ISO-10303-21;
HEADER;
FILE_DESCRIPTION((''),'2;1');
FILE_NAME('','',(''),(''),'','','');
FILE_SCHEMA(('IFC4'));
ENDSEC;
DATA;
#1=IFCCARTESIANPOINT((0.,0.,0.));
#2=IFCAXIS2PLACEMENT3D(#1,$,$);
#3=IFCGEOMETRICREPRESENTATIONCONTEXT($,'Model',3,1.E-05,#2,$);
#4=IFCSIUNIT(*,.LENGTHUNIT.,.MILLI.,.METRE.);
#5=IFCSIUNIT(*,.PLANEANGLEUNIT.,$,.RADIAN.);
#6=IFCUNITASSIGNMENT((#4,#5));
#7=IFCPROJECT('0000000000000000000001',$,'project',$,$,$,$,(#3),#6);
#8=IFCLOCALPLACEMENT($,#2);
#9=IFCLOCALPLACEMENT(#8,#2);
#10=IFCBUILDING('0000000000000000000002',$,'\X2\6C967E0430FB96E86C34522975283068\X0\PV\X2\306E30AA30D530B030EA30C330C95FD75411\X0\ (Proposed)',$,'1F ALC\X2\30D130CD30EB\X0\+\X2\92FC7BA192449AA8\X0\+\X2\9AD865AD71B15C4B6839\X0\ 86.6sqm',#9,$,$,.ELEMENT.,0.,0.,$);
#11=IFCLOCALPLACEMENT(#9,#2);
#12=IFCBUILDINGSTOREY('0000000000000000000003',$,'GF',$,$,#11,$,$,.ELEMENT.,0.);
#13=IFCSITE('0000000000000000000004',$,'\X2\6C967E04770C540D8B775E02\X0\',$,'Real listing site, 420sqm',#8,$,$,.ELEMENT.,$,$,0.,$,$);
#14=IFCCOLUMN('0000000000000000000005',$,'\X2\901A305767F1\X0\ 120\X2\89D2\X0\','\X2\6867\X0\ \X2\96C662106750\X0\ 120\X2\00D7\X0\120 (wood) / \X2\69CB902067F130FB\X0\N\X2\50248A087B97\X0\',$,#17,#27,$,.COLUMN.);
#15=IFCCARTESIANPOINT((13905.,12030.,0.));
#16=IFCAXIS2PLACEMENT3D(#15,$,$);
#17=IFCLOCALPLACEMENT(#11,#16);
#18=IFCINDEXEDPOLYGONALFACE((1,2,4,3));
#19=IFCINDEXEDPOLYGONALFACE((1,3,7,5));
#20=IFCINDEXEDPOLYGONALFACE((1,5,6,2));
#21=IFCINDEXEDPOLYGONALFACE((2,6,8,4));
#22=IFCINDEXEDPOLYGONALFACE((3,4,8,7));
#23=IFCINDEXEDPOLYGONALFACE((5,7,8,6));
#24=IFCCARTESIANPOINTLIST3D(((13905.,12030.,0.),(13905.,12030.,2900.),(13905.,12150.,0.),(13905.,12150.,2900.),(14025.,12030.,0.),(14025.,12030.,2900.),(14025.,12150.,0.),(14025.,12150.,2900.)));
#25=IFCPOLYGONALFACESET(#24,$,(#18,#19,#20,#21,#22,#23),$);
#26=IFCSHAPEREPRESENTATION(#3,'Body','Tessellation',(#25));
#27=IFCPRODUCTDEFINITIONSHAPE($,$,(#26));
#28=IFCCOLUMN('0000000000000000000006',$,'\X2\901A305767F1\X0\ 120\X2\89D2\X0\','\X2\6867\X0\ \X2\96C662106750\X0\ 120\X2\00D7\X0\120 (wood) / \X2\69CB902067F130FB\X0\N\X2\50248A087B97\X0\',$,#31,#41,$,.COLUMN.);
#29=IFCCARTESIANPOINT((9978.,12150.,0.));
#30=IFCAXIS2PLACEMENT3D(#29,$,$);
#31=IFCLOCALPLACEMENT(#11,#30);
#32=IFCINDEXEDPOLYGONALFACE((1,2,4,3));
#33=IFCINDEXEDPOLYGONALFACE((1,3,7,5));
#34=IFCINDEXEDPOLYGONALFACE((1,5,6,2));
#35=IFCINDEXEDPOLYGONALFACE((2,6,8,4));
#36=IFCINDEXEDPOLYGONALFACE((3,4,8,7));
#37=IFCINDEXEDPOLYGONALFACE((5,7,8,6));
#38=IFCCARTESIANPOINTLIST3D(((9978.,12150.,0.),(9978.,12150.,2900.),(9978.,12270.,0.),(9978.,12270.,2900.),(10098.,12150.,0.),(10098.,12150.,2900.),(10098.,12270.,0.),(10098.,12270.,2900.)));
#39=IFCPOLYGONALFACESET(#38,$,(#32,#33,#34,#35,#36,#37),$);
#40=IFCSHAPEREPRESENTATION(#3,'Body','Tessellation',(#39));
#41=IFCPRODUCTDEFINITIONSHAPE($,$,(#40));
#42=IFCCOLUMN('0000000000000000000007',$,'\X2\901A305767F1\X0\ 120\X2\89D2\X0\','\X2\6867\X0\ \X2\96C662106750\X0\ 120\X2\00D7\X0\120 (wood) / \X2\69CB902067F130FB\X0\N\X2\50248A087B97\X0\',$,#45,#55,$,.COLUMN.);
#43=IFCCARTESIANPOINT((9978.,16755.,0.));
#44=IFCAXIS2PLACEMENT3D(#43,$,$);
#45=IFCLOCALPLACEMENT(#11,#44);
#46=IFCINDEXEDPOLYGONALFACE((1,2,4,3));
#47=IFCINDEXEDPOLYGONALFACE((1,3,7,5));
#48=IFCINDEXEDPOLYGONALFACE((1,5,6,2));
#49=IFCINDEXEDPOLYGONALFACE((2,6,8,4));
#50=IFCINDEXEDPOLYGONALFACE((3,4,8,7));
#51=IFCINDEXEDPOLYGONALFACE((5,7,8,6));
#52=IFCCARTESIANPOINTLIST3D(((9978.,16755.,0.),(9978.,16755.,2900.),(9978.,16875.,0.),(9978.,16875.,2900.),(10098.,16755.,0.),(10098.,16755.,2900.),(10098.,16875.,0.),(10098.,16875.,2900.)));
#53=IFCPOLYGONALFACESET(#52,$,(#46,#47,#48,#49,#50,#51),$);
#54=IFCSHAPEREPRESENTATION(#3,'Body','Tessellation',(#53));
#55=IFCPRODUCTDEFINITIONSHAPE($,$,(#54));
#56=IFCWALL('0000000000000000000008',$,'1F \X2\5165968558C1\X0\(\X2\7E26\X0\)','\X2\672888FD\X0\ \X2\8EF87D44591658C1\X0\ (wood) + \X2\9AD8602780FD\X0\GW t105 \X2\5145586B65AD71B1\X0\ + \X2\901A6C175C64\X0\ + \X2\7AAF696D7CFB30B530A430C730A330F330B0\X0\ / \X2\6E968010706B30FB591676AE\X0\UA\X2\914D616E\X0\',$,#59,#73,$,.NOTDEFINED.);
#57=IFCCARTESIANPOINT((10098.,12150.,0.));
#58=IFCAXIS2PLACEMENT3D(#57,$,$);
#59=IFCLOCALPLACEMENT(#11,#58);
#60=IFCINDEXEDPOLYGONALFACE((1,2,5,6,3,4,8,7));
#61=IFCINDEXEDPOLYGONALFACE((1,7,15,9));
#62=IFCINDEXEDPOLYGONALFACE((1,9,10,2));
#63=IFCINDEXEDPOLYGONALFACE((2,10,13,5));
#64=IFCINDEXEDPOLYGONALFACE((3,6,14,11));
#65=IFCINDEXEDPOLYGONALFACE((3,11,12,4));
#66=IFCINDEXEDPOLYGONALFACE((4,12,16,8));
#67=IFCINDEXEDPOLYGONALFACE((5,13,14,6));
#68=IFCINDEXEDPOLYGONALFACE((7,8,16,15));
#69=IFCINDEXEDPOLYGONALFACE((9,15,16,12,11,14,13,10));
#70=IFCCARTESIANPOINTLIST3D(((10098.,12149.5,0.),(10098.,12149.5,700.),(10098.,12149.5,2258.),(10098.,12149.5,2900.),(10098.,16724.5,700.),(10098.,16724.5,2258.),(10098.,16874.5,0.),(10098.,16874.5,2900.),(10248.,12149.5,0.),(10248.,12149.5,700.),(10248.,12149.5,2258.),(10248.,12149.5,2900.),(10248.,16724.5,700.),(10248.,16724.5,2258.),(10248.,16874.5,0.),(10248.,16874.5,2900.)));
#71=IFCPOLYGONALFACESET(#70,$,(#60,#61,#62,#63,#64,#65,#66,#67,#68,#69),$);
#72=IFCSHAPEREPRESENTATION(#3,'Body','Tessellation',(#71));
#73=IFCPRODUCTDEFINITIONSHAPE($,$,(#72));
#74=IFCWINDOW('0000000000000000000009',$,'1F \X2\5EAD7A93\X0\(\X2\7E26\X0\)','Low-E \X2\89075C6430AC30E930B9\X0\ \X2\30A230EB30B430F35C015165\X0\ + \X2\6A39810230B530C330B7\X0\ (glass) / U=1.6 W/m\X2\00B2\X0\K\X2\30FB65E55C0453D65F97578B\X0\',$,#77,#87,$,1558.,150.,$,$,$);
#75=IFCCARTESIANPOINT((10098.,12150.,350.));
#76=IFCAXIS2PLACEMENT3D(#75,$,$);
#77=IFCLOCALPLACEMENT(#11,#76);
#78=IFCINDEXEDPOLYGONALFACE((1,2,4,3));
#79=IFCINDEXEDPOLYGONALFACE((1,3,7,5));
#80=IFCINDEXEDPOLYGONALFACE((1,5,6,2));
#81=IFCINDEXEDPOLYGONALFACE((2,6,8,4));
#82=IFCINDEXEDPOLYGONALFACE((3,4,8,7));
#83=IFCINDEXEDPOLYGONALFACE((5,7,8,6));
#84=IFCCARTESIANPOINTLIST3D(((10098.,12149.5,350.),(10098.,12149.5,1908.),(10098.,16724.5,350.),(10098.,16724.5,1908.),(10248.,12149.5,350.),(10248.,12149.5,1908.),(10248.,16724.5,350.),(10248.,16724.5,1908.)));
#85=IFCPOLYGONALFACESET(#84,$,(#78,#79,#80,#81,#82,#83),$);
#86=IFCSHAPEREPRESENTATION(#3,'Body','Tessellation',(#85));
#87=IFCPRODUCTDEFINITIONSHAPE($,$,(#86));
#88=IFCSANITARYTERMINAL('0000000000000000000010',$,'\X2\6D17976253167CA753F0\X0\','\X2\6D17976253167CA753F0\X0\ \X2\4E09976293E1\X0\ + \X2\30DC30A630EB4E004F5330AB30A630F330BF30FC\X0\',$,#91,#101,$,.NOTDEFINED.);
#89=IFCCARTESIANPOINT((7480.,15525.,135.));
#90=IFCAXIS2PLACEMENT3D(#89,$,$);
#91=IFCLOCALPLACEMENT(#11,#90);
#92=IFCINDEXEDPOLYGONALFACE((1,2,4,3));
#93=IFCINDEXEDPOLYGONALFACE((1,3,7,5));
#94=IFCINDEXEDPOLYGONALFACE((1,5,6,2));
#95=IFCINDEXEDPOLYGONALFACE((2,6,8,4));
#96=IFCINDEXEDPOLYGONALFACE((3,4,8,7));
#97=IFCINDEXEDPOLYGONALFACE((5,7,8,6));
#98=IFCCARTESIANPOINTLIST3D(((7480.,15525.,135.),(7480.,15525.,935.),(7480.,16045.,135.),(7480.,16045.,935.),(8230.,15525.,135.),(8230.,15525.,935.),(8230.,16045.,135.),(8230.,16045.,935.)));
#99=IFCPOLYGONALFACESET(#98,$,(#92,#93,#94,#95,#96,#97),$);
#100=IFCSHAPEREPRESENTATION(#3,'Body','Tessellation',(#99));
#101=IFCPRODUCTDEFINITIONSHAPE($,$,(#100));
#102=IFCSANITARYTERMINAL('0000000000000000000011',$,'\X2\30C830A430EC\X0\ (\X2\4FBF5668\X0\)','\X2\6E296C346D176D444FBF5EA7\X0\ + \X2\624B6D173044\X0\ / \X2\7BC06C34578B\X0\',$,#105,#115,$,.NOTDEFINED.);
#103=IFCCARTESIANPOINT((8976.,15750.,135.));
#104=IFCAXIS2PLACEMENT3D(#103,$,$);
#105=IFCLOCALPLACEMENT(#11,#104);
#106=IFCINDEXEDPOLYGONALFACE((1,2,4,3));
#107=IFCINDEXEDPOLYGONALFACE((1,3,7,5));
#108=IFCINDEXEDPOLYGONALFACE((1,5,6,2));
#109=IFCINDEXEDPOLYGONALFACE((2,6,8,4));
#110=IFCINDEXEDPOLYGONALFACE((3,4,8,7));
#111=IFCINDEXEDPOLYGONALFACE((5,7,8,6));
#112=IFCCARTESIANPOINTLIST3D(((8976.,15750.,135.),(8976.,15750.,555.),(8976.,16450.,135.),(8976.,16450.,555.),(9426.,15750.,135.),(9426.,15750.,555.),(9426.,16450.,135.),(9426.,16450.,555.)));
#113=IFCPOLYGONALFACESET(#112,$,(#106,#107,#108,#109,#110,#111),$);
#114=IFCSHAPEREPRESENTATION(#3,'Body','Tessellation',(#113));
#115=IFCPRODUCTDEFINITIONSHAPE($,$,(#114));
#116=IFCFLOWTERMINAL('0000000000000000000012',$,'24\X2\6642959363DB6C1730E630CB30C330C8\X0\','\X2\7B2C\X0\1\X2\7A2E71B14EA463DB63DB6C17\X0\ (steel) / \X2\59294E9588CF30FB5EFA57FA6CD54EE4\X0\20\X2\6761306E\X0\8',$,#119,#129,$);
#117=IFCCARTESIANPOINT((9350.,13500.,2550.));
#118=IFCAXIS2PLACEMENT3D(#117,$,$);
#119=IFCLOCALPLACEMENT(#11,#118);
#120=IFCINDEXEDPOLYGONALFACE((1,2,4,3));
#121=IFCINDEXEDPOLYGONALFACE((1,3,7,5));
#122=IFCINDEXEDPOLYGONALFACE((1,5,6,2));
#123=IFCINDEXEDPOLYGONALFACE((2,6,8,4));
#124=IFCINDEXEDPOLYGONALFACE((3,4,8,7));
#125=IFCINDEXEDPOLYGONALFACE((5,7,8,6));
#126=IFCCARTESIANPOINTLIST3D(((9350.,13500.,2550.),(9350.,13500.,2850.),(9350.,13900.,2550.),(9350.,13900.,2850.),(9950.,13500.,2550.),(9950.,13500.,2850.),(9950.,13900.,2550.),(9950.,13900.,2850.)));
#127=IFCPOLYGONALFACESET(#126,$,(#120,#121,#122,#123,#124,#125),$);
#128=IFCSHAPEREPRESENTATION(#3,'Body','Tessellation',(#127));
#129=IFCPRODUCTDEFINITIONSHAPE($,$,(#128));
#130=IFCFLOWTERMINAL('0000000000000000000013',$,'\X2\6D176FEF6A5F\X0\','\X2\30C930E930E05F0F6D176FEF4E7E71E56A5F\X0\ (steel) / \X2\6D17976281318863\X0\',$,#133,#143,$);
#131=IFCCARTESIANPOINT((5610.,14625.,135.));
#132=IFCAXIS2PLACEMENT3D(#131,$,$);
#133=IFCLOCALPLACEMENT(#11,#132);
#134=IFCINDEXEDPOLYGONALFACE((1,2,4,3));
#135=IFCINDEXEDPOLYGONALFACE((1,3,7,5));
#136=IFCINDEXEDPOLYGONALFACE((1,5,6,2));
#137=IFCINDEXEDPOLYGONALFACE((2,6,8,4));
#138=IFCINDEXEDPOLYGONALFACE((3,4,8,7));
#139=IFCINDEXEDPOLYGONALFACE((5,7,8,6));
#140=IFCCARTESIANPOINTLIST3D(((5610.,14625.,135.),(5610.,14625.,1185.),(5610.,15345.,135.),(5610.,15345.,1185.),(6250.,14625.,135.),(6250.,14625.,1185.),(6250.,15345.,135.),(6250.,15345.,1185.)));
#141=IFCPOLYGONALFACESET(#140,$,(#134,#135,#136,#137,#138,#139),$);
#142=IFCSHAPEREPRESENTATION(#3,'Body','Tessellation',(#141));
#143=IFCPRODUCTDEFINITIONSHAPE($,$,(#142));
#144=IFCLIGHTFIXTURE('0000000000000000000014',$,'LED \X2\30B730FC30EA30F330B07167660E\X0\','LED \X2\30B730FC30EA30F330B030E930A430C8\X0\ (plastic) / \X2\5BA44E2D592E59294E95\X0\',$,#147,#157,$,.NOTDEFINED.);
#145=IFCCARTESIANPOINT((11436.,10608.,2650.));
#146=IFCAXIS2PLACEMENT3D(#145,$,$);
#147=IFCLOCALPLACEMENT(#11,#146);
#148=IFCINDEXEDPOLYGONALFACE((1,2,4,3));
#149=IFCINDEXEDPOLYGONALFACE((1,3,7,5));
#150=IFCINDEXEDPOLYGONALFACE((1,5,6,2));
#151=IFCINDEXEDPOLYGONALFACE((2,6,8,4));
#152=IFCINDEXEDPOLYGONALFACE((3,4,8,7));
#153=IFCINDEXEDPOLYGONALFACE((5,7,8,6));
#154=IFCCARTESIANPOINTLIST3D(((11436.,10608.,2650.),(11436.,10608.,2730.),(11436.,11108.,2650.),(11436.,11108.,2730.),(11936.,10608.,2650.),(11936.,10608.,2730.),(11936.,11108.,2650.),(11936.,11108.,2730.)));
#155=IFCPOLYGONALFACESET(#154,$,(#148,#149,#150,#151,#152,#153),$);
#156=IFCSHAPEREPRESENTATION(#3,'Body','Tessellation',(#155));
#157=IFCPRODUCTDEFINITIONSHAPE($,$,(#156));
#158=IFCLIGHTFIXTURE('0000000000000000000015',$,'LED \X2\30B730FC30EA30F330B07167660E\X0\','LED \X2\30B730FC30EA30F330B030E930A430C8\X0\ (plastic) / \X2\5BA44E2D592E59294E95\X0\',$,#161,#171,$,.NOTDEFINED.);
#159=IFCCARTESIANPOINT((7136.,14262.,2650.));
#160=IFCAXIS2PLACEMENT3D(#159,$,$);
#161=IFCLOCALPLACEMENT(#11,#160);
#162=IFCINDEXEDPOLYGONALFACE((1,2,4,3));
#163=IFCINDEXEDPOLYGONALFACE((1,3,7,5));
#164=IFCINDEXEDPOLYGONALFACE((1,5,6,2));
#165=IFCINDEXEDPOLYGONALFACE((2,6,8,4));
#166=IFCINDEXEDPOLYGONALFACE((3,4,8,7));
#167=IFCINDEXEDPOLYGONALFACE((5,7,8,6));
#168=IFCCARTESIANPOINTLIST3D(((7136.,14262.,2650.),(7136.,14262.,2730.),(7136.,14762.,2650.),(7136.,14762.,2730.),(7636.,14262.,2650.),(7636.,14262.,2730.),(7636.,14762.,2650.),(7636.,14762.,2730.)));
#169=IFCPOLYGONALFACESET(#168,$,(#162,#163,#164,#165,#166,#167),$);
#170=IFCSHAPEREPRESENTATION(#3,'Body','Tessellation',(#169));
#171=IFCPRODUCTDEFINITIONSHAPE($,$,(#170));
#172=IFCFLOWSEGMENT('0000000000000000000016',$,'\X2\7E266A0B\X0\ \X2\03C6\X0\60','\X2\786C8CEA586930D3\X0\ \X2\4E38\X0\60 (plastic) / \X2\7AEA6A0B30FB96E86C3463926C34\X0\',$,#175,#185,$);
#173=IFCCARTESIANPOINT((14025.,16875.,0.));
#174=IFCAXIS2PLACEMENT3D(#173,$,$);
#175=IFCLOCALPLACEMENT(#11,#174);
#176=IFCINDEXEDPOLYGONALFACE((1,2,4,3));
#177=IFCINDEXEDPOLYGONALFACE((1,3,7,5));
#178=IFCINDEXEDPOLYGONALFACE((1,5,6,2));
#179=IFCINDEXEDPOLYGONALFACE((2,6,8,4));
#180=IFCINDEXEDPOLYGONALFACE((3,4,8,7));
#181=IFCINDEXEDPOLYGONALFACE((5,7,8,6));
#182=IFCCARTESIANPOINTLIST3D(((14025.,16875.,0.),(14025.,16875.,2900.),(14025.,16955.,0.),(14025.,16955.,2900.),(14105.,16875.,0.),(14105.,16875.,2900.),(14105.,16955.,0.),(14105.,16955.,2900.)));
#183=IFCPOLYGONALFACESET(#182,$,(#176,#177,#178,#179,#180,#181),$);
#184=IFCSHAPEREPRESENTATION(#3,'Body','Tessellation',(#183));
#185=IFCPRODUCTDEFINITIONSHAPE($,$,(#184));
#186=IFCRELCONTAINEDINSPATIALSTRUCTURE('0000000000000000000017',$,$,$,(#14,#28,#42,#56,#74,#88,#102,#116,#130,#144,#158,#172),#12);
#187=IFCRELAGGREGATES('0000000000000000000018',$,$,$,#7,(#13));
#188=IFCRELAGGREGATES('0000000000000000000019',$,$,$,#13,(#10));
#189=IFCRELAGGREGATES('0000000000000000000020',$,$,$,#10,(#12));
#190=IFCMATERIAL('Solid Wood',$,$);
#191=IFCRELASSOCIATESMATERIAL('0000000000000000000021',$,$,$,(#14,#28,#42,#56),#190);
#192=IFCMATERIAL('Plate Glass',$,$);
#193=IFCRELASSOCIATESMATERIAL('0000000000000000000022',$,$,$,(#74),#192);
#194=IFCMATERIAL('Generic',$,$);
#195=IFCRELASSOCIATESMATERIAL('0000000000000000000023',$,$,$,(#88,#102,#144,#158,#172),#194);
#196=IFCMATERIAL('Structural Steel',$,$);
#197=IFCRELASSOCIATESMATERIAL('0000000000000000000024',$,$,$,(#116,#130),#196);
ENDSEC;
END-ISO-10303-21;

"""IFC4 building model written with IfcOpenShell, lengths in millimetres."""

from ifc_helpers import new_model, si_unit, frame, frame_2d, origin, place, context, project, spatial, rectangle, extrude, material, element, fill, save


model = new_model("IFC4")

# Units and contexts
model_context = context("Model", 3, precision=1e-05, world=origin())
ifc_project = project(units=[si_unit("LENGTHUNIT", "METRE", prefix="MILLI"), si_unit("PLANEANGLEUNIT", "RADIAN")], contexts=[model_context])

# Site, building, storey
site_placement = place(None, origin())
site = spatial("IfcSite", under=ifc_project, at=site_placement, Name="沖縄県名護市", ObjectType="Real listing site, 420sqm", CompositionType="ELEMENT", RefElevation=0.0)
building_placement = place(site_placement, origin())
building = spatial("IfcBuilding", under=site, at=building_placement, Name="沖縄・雨水利用とPVのオフグリッド志向 (Proposed)", ObjectType="1F ALCパネル+鋼管鉄骨+高断熱屋根 86.6sqm", CompositionType="ELEMENT", ElevationOfRefHeight=0.0, ElevationOfTerrain=0.0)
storey_placement = place(building_placement, origin())
storey = spatial("IfcBuildingStorey", under=building, at=storey_placement, Name="GF", CompositionType="ELEMENT", Elevation=0.0)

# Columns
ifc_material_1 = material(Name="Solid Wood")
column_1_placement = place(storey_placement, frame((13905.0, 12030.0, 0.0)))
element("IfcColumn", 1, at=column_1_placement, inside=storey, material=ifc_material_1, Name="通し柱 120角", Description="桧 集成材 120×120 (wood) / 構造柱・N値計算", PredefinedType="COLUMN", context=model_context, shape_type="SweptSolid", body=[
    extrude(rectangle(XDim=120.0, YDim=120.0, at=frame_2d((60.0, 60.0))), frame((13905.0, 12030.0, 0.0)), (0.0, 0.0, 1.0), 2900.0),
])
column_2_placement = place(storey_placement, frame((9978.0, 12150.0, 0.0)))
element("IfcColumn", 2, at=column_2_placement, inside=storey, material=ifc_material_1, Name="通し柱 120角", Description="桧 集成材 120×120 (wood) / 構造柱・N値計算", PredefinedType="COLUMN", context=model_context, shape_type="SweptSolid", body=[
    extrude(rectangle(XDim=120.0, YDim=120.0, at=frame_2d((60.0, 60.0))), frame((9978.0, 12150.0, 0.0)), (0.0, 0.0, 1.0), 2900.0),
])
column_3_placement = place(storey_placement, frame((9978.0, 16755.0, 0.0)))
element("IfcColumn", 3, at=column_3_placement, inside=storey, material=ifc_material_1, Name="通し柱 120角", Description="桧 集成材 120×120 (wood) / 構造柱・N値計算", PredefinedType="COLUMN", context=model_context, shape_type="SweptSolid", body=[
    extrude(rectangle(XDim=120.0, YDim=120.0, at=frame_2d((60.0, 60.0))), frame((9978.0, 16755.0, 0.0)), (0.0, 0.0, 1.0), 2900.0),
])

# Wall, opening, window
wall_1_placement = place(storey_placement, frame((10098.0, 12150.0, 0.0)))
wall_1 = element("IfcWall", 4, at=wall_1_placement, inside=storey, material=ifc_material_1, Name="1F 入隅壁(縦)", Description="木製 軸組外壁 (wood) + 高性能GW t105 充填断熱 + 通気層 + 窯業系サイディング / 準耐火・外皮UA配慮", PredefinedType="NOTDEFINED", context=model_context, shape_type="SweptSolid", body=[
    extrude(rectangle(XDim=150.0, YDim=4725.0, at=frame_2d((75.0, 2362.0))), frame((10098.0, 12150.0, 0.0)), (0.0, 0.0, 1.0), 2900.0),
])
opening_placement = place(storey_placement, frame((10098.0, 12150.0, 350.0)))
opening = element("IfcOpeningElement", 5, at=opening_placement, cuts=wall_1, PredefinedType="NOTDEFINED", context=model_context, shape_type="SweptSolid", body=[
    extrude(rectangle(XDim=150.0, YDim=4575.0, at=frame_2d((75.0, 2287.0))), frame((10098.0, 12150.0, 350.0)), (0.0, 0.0, 1.0), 1558.0),
])
ifc_material_2 = material(Name="Plate Glass")
window_placement = place(storey_placement, frame((10098.0, 12150.0, 350.0)))
window = element("IfcWindow", 6, at=window_placement, inside=storey, material=ifc_material_2, Name="1F 庭窓(縦)", Description="Low-E 複層ガラス アルゴン封入 + 樹脂サッシ (glass) / U=1.6 W/m²K・日射取得型", OverallHeight=1558.0, OverallWidth=150.0, context=model_context, shape_type="SweptSolid", body=[
    extrude(rectangle(XDim=150.0, YDim=4575.0, at=frame_2d((75.0, 2287.0))), frame((10098.0, 12150.0, 350.0)), (0.0, 0.0, 1.0), 1558.0),
])
fill(opening, window)

# Sanitary terminals
ifc_material_3 = material(Name="Generic")
sanitary_terminal_1_placement = place(storey_placement, frame((7480.0, 15525.0, 135.0)))
element("IfcSanitaryTerminal", 7, at=sanitary_terminal_1_placement, inside=storey, material=ifc_material_3, Name="洗面化粧台", Description="洗面化粧台 三面鏡 + ボウル一体カウンター", PredefinedType="NOTDEFINED", context=model_context, shape_type="SweptSolid", body=[
    extrude(rectangle(XDim=750.0, YDim=520.0, at=frame_2d((375.0, 260.0))), frame((7480.0, 15525.0, 135.0)), (0.0, 0.0, 1.0), 800.0),
])
sanitary_terminal_2_placement = place(storey_placement, frame((8976.0, 15750.0, 135.0)))
element("IfcSanitaryTerminal", 8, at=sanitary_terminal_2_placement, inside=storey, material=ifc_material_3, Name="トイレ (便器)", Description="温水洗浄便座 + 手洗い / 節水型", PredefinedType="NOTDEFINED", context=model_context, shape_type="SweptSolid", body=[
    extrude(rectangle(XDim=450.0, YDim=700.0, at=frame_2d((225.0, 350.0))), frame((8976.0, 15750.0, 135.0)), (0.0, 0.0, 1.0), 420.0),
])

# Flow terminals
ifc_material_4 = material(Name="Structural Steel")
flow_terminal_1_placement = place(storey_placement, frame((9350.0, 13500.0, 2550.0)))
element("IfcFlowTerminal", 9, at=flow_terminal_1_placement, inside=storey, material=ifc_material_4, Name="24時間換気ユニット", Description="第1種熱交換換気 (steel) / 天井裏・建基法令20条の8", context=model_context, shape_type="SweptSolid", body=[
    extrude(rectangle(XDim=600.0, YDim=400.0, at=frame_2d((300.0, 200.0))), frame((9350.0, 13500.0, 2550.0)), (0.0, 0.0, 1.0), 300.0),
])
flow_terminal_2_placement = place(storey_placement, frame((5610.0, 14625.0, 135.0)))
element("IfcFlowTerminal", 10, at=flow_terminal_2_placement, inside=storey, material=ifc_material_4, Name="洗濯機", Description="ドラム式洗濯乾燥機 (steel) / 洗面脱衣", context=model_context, shape_type="SweptSolid", body=[
    extrude(rectangle(XDim=640.0, YDim=720.0, at=frame_2d((320.0, 360.0))), frame((5610.0, 14625.0, 135.0)), (0.0, 0.0, 1.0), 1050.0),
])

# Light fixtures
light_fixture_1_placement = place(storey_placement, frame((11436.0, 10608.0, 2650.0)))
element("IfcLightFixture", 11, at=light_fixture_1_placement, inside=storey, material=ifc_material_3, Name="LED シーリング照明", Description="LED シーリングライト (plastic) / 室中央天井", PredefinedType="NOTDEFINED", context=model_context, shape_type="SweptSolid", body=[
    extrude(rectangle(XDim=500.0, YDim=500.0, at=frame_2d((250.0, 250.0))), frame((11436.0, 10608.0, 2650.0)), (0.0, 0.0, 1.0), 80.0),
])
light_fixture_2_placement = place(storey_placement, frame((7136.0, 14262.0, 2650.0)))
element("IfcLightFixture", 12, at=light_fixture_2_placement, inside=storey, material=ifc_material_3, Name="LED シーリング照明", Description="LED シーリングライト (plastic) / 室中央天井", PredefinedType="NOTDEFINED", context=model_context, shape_type="SweptSolid", body=[
    extrude(rectangle(XDim=500.0, YDim=500.0, at=frame_2d((250.0, 250.0))), frame((7136.0, 14262.0, 2650.0)), (0.0, 0.0, 1.0), 80.0),
])

# Flow segment
flow_segment_placement = place(storey_placement, frame((14025.0, 16875.0, 0.0)))
element("IfcFlowSegment", 13, at=flow_segment_placement, inside=storey, material=ifc_material_3, Name="縦樋 φ60", Description="硬質塩ビ 丸60 (plastic) / 竪樋・雨水排水", context=model_context, shape_type="SweptSolid", body=[
    extrude(rectangle(XDim=80.0, YDim=80.0, at=frame_2d((40.0, 40.0))), frame((14025.0, 16875.0, 0.0)), (0.0, 0.0, 1.0), 2900.0),
])

save(model, "model.ifc")
